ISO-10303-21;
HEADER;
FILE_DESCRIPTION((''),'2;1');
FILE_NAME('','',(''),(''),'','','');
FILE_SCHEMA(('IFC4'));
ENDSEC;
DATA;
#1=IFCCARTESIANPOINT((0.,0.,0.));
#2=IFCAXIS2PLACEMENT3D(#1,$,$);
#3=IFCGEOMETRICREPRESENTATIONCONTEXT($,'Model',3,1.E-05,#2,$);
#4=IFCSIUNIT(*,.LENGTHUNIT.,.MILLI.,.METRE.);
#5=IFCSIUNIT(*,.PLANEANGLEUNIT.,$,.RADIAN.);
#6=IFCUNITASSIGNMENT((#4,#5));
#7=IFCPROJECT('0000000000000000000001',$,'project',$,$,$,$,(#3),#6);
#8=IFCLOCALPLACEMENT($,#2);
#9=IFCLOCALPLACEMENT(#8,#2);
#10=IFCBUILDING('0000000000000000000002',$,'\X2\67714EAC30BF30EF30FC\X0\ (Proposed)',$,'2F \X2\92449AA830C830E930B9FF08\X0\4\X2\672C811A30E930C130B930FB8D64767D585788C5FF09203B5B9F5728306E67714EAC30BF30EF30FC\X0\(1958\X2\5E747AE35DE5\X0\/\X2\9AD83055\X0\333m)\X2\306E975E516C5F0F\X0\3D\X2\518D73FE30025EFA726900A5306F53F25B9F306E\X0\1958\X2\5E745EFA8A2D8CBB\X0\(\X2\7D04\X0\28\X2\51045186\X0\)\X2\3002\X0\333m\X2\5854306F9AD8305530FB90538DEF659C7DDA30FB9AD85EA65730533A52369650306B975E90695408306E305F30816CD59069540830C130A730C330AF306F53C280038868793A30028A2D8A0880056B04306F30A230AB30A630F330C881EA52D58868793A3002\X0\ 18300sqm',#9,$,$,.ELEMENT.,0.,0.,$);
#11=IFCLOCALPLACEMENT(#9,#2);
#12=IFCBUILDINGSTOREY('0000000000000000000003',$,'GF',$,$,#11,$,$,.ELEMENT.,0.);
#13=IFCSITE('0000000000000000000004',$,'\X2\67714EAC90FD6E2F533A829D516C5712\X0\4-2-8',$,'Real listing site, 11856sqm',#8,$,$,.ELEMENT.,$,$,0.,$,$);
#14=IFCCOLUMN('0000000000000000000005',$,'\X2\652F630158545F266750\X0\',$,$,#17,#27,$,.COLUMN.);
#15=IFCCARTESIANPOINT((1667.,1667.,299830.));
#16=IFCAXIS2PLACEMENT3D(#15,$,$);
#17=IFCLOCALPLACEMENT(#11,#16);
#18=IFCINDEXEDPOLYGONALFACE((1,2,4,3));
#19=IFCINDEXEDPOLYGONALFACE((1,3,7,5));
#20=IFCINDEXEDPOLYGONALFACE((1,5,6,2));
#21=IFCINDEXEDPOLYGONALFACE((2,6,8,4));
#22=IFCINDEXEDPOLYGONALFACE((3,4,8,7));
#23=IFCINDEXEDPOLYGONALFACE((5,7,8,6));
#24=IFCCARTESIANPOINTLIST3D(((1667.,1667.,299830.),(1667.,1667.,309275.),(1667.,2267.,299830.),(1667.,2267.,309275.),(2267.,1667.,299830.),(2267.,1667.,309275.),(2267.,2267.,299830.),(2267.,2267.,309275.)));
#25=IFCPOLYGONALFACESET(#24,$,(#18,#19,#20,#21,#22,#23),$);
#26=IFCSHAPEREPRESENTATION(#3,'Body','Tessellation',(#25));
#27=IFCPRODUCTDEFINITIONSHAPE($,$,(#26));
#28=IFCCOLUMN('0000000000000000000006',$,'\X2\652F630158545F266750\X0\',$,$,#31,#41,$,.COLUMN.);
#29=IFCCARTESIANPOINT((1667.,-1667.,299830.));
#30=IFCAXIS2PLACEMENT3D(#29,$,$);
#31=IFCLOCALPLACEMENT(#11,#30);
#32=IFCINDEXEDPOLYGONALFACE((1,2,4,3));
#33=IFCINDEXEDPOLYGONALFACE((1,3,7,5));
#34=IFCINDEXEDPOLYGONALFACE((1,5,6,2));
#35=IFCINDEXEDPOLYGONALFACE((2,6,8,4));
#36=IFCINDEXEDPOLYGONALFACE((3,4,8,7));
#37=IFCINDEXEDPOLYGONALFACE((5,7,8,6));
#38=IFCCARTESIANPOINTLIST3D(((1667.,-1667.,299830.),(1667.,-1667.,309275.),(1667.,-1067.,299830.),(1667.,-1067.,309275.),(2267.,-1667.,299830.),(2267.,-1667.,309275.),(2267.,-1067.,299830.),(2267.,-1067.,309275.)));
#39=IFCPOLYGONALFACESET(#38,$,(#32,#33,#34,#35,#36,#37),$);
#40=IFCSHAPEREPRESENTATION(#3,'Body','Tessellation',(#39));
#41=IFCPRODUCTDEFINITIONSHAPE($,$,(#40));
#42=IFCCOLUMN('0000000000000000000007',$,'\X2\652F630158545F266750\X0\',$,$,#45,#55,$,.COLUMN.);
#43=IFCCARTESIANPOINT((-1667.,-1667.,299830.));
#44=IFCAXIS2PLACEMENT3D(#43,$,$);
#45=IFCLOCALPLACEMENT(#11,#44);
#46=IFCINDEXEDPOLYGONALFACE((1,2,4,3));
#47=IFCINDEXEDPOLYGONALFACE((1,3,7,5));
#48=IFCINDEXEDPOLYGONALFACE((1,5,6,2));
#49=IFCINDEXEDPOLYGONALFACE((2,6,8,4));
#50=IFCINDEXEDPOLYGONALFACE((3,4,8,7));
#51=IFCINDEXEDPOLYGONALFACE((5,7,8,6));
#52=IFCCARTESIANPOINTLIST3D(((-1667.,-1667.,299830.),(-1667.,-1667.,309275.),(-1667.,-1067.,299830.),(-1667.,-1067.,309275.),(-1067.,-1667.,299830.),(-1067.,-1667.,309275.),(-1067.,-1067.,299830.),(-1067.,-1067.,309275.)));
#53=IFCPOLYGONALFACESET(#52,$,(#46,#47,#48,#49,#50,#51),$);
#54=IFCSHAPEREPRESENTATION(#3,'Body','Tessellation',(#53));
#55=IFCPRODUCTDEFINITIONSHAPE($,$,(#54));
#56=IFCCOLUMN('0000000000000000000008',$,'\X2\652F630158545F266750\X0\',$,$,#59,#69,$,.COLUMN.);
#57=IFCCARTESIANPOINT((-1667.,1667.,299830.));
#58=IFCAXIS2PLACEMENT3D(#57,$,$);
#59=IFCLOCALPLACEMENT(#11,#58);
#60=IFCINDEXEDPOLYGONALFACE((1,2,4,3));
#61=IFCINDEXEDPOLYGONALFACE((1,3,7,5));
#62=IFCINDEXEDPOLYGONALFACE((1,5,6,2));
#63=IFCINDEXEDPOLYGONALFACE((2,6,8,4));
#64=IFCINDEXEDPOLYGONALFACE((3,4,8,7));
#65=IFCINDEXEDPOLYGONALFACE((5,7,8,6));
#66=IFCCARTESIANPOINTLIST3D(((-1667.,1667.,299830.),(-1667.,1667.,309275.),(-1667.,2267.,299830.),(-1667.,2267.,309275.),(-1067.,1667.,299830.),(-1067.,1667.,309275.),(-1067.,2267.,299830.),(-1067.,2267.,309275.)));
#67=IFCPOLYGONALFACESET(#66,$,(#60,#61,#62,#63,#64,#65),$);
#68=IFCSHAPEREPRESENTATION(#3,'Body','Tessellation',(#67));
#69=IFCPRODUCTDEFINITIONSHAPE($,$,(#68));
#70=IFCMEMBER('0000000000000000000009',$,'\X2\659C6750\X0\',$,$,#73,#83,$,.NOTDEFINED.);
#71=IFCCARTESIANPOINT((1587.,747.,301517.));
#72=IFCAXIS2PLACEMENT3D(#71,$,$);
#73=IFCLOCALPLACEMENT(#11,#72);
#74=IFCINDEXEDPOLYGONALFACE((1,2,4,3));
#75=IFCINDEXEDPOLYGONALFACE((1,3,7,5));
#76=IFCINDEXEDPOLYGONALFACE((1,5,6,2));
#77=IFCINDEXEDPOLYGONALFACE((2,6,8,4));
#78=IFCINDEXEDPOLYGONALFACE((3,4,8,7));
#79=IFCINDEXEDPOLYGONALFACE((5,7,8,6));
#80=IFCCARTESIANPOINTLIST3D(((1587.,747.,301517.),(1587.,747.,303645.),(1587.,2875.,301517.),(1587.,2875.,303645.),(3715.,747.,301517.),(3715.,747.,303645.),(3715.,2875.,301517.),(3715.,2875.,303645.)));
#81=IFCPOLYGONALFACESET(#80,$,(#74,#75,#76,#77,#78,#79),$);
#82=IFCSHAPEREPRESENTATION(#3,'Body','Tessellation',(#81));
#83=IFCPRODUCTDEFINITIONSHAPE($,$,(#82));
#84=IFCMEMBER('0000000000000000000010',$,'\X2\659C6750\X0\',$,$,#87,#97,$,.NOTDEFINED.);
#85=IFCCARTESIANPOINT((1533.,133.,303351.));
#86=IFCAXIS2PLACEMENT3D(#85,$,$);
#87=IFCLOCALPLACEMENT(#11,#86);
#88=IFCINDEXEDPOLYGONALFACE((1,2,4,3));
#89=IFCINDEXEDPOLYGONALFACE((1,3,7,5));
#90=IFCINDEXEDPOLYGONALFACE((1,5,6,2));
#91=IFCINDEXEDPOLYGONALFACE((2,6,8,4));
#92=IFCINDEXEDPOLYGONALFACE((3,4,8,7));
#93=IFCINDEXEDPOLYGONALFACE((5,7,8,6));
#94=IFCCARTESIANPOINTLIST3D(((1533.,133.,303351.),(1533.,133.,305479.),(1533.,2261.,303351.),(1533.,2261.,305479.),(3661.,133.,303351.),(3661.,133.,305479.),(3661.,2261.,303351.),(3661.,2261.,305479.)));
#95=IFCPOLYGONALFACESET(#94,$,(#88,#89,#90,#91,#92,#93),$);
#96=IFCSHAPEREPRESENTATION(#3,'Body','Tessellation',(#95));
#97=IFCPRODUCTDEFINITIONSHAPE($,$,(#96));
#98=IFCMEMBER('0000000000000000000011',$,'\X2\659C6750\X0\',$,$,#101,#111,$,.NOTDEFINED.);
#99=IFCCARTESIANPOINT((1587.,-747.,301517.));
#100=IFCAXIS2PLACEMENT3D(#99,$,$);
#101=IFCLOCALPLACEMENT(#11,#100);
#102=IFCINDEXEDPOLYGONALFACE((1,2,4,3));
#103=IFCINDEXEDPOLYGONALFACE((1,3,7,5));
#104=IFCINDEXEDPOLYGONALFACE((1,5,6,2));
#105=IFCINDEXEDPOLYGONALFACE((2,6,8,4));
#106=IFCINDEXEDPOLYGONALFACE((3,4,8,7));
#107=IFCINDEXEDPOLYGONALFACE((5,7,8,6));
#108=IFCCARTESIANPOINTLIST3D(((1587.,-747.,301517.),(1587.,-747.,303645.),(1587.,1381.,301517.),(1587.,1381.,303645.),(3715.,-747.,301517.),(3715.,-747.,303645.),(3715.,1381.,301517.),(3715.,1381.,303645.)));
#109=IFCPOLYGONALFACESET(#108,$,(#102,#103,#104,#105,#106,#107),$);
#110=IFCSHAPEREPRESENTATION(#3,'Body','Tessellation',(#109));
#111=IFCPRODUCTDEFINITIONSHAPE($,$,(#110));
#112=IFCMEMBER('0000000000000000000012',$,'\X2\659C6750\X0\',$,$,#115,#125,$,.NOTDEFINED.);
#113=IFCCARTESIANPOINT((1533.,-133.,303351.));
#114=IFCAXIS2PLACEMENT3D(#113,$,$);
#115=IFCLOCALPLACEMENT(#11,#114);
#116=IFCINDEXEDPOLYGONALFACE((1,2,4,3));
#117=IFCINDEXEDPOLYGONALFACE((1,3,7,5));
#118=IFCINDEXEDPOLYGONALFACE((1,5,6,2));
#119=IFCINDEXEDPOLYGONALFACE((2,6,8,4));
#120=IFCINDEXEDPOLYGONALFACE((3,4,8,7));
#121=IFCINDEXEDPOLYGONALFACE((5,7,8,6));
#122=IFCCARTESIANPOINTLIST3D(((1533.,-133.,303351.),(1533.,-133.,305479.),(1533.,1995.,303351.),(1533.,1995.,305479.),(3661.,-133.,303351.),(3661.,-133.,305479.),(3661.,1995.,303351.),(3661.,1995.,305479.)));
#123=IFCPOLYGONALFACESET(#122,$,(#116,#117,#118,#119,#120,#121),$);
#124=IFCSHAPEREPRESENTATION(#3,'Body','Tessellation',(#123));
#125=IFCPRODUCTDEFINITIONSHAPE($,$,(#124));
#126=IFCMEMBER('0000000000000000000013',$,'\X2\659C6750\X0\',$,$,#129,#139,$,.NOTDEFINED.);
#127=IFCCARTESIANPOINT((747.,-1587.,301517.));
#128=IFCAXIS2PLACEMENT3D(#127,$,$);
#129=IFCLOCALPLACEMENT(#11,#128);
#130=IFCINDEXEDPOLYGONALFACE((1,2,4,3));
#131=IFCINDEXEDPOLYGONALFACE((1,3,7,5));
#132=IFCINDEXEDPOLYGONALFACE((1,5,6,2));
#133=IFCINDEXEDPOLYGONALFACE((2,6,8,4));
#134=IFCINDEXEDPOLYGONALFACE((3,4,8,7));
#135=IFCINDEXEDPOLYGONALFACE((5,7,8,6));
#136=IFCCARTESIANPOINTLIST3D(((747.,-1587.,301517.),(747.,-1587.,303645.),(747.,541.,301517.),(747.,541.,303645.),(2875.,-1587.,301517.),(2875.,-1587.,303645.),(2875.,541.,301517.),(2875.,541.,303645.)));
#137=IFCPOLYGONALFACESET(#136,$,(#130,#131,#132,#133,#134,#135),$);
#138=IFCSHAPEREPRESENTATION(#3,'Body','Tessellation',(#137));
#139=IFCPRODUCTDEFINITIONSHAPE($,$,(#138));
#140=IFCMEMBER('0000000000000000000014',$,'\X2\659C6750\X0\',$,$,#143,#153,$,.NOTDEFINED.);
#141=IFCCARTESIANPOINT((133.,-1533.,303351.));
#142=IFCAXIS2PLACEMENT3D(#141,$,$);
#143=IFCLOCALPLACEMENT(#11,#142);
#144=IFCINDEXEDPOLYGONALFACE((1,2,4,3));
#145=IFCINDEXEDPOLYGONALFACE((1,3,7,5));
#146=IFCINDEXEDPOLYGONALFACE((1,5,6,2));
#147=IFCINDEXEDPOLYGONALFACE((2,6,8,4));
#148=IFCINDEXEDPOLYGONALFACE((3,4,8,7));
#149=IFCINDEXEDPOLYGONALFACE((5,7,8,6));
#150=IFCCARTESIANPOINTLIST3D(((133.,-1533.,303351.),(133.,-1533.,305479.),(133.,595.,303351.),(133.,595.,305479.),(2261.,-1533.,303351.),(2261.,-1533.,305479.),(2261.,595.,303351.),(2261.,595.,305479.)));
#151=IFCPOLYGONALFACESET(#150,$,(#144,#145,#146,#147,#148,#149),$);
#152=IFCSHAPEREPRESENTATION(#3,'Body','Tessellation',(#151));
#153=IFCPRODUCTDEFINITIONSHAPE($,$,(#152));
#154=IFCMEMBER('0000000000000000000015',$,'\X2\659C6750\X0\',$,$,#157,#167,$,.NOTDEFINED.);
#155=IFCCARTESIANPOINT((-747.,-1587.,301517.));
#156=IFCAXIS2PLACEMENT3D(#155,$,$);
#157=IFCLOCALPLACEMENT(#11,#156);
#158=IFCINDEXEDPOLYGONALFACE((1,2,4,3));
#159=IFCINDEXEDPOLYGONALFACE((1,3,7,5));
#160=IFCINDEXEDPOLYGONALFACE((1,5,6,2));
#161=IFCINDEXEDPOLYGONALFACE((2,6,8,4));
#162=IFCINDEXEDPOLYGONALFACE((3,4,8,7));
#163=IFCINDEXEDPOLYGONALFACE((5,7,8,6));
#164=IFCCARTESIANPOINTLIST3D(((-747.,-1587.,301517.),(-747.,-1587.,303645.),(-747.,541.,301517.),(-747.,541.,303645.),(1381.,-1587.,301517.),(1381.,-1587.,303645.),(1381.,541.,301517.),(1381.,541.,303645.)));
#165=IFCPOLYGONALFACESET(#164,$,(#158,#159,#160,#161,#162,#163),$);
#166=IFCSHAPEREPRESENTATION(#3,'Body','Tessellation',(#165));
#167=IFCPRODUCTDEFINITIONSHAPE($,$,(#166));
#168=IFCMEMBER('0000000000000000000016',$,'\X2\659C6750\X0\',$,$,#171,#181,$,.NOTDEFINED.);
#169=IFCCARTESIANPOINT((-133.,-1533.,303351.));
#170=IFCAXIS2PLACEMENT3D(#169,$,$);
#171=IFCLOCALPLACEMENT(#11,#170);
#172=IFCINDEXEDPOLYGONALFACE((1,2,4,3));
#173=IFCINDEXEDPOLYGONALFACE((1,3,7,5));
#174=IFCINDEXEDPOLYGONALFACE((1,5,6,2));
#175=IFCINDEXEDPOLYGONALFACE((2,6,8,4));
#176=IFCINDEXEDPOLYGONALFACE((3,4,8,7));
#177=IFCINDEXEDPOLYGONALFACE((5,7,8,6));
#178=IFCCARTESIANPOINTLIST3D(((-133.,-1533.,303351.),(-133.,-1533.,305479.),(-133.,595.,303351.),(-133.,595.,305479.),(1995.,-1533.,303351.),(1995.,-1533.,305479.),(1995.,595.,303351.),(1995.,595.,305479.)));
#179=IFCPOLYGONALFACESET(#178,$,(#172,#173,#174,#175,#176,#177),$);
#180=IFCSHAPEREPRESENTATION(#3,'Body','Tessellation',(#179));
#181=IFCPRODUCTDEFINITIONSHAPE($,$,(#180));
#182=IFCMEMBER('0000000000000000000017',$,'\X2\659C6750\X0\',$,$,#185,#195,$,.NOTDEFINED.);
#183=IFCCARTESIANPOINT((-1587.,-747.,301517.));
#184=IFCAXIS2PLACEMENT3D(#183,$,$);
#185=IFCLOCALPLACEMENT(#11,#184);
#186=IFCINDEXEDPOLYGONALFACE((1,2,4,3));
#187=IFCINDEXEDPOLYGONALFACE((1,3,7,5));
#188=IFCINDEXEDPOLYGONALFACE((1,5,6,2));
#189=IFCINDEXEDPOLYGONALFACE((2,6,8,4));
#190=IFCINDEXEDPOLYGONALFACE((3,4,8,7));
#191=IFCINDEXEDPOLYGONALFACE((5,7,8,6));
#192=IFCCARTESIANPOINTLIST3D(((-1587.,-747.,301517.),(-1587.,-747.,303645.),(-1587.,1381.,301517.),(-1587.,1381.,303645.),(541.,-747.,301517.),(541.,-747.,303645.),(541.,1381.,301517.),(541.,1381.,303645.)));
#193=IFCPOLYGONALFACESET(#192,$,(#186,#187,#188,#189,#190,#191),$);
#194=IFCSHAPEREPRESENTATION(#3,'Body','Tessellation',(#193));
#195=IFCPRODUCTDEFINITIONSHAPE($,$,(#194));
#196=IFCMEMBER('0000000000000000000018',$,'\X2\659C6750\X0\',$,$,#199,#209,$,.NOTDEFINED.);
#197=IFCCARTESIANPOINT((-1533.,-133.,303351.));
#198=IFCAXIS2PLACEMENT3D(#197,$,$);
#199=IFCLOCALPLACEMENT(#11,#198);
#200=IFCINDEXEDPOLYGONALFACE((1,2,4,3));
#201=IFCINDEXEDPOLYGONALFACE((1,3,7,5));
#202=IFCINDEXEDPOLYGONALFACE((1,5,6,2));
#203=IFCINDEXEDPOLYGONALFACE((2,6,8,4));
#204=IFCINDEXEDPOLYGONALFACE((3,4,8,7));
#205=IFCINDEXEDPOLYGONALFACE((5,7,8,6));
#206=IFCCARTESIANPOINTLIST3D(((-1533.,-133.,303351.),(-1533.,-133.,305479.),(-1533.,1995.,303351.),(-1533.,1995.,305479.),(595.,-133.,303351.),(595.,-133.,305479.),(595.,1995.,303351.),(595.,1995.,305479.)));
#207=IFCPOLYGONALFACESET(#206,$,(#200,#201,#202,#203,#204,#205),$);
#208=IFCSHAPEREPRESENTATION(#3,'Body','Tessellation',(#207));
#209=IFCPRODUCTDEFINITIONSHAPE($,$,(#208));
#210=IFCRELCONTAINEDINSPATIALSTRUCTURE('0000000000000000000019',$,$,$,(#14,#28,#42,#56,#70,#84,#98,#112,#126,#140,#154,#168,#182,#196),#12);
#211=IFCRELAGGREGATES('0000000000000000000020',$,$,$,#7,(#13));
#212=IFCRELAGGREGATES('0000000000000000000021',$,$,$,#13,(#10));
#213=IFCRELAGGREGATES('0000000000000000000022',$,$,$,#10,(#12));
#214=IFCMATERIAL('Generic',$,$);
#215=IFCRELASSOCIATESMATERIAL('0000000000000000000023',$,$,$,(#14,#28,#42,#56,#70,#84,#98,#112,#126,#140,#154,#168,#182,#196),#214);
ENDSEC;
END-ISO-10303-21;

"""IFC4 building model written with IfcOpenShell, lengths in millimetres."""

from ifc_helpers import new_model, si_unit, frame, frame_2d, origin, place, context, project, spatial, rectangle, extrude, material, element, save


model = new_model("IFC4")

# Units and contexts
model_context = context("Model", 3, precision=1e-05, world=origin())
ifc_project = project(units=[si_unit("LENGTHUNIT", "METRE", prefix="MILLI"), si_unit("PLANEANGLEUNIT", "RADIAN")], contexts=[model_context])

# Site, building, storey
site_placement = place(None, origin())
site = spatial("IfcSite", under=ifc_project, at=site_placement, Name="東京都港区芝公園4-2-8", ObjectType="Real listing site, 11856sqm", CompositionType="ELEMENT", RefElevation=0.0)
building_placement = place(site_placement, origin())
building = spatial("IfcBuilding", under=site, at=building_placement, Name="東京タワー (Proposed)", ObjectType="2F 鉄骨トラス（4本脚ラチス・赤白塗装）※実在の東京タワー(1958年竣工/高さ333m)の非公式3D再現。建物¥は史実の1958年建設費(約28億円)。333m塔は高さ・道路斜線・高度地区制限に非適合のため法適合チェックは参考表示。設計者欄はアカウント自動表示。 18300sqm", CompositionType="ELEMENT", ElevationOfRefHeight=0.0, ElevationOfTerrain=0.0)
storey_placement = place(building_placement, origin())
storey = spatial("IfcBuildingStorey", under=building, at=storey_placement, Name="GF", CompositionType="ELEMENT", Elevation=0.0)

# Columns
ifc_material = material(Name="Generic")
column_1_placement = place(storey_placement, frame((1667.0, 1667.0, 299830.0)))
element("IfcColumn", 1, at=column_1_placement, inside=storey, material=ifc_material, Name="支持塔弦材", PredefinedType="COLUMN", context=model_context, shape_type="SweptSolid", body=[
    extrude(rectangle(XDim=600.0, YDim=600.0, at=frame_2d((300.0, 300.0))), frame((1667.0, 1667.0, 299830.0)), (0.0, 0.0, 1.0), 9445.0),
])
column_2_placement = place(storey_placement, frame((1667.0, -1667.0, 299830.0)))
element("IfcColumn", 2, at=column_2_placement, inside=storey, material=ifc_material, Name="支持塔弦材", PredefinedType="COLUMN", context=model_context, shape_type="SweptSolid", body=[
    extrude(rectangle(XDim=600.0, YDim=600.0, at=frame_2d((300.0, 300.0))), frame((1667.0, -1667.0, 299830.0)), (0.0, 0.0, 1.0), 9445.0),
])
column_3_placement = place(storey_placement, frame((-1667.0, -1667.0, 299830.0)))
element("IfcColumn", 3, at=column_3_placement, inside=storey, material=ifc_material, Name="支持塔弦材", PredefinedType="COLUMN", context=model_context, shape_type="SweptSolid", body=[
    extrude(rectangle(XDim=600.0, YDim=600.0, at=frame_2d((300.0, 300.0))), frame((-1667.0, -1667.0, 299830.0)), (0.0, 0.0, 1.0), 9445.0),
])
column_4_placement = place(storey_placement, frame((-1667.0, 1667.0, 299830.0)))
element("IfcColumn", 4, at=column_4_placement, inside=storey, material=ifc_material, Name="支持塔弦材", PredefinedType="COLUMN", context=model_context, shape_type="SweptSolid", body=[
    extrude(rectangle(XDim=600.0, YDim=600.0, at=frame_2d((300.0, 300.0))), frame((-1667.0, 1667.0, 299830.0)), (0.0, 0.0, 1.0), 9445.0),
])

# Members
member_1_placement = place(storey_placement, frame((1587.0, 747.0, 301517.0)))
element("IfcMember", 5, at=member_1_placement, inside=storey, material=ifc_material, Name="斜材", PredefinedType="NOTDEFINED", context=model_context, shape_type="SweptSolid", body=[
    extrude(rectangle(XDim=2128.0, YDim=2128.0, at=frame_2d((1064.0, 1064.0))), frame((1587.0, 747.0, 301517.0)), (0.0, 0.0, 1.0), 2128.0),
])
member_2_placement = place(storey_placement, frame((1533.0, 133.0, 303351.0)))
element("IfcMember", 6, at=member_2_placement, inside=storey, material=ifc_material, Name="斜材", PredefinedType="NOTDEFINED", context=model_context, shape_type="SweptSolid", body=[
    extrude(rectangle(XDim=2128.0, YDim=2128.0, at=frame_2d((1064.0, 1064.0))), frame((1533.0, 133.0, 303351.0)), (0.0, 0.0, 1.0), 2128.0),
])
member_3_placement = place(storey_placement, frame((1587.0, -747.0, 301517.0)))
element("IfcMember", 7, at=member_3_placement, inside=storey, material=ifc_material, Name="斜材", PredefinedType="NOTDEFINED", context=model_context, shape_type="SweptSolid", body=[
    extrude(rectangle(XDim=2128.0, YDim=2128.0, at=frame_2d((1064.0, 1064.0))), frame((1587.0, -747.0, 301517.0)), (0.0, 0.0, 1.0), 2128.0),
])
member_4_placement = place(storey_placement, frame((1533.0, -133.0, 303351.0)))
element("IfcMember", 8, at=member_4_placement, inside=storey, material=ifc_material, Name="斜材", PredefinedType="NOTDEFINED", context=model_context, shape_type="SweptSolid", body=[
    extrude(rectangle(XDim=2128.0, YDim=2128.0, at=frame_2d((1064.0, 1064.0))), frame((1533.0, -133.0, 303351.0)), (0.0, 0.0, 1.0), 2128.0),
])
member_5_placement = place(storey_placement, frame((747.0, -1587.0, 301517.0)))
element("IfcMember", 9, at=member_5_placement, inside=storey, material=ifc_material, Name="斜材", PredefinedType="NOTDEFINED", context=model_context, shape_type="SweptSolid", body=[
    extrude(rectangle(XDim=2128.0, YDim=2128.0, at=frame_2d((1064.0, 1064.0))), frame((747.0, -1587.0, 301517.0)), (0.0, 0.0, 1.0), 2128.0),
])
member_6_placement = place(storey_placement, frame((133.0, -1533.0, 303351.0)))
element("IfcMember", 10, at=member_6_placement, inside=storey, material=ifc_material, Name="斜材", PredefinedType="NOTDEFINED", context=model_context, shape_type="SweptSolid", body=[
    extrude(rectangle(XDim=2128.0, YDim=2128.0, at=frame_2d((1064.0, 1064.0))), frame((133.0, -1533.0, 303351.0)), (0.0, 0.0, 1.0), 2128.0),
])
member_7_placement = place(storey_placement, frame((-747.0, -1587.0, 301517.0)))
element("IfcMember", 11, at=member_7_placement, inside=storey, material=ifc_material, Name="斜材", PredefinedType="NOTDEFINED", context=model_context, shape_type="SweptSolid", body=[
    extrude(rectangle(XDim=2128.0, YDim=2128.0, at=frame_2d((1064.0, 1064.0))), frame((-747.0, -1587.0, 301517.0)), (0.0, 0.0, 1.0), 2128.0),
])
member_8_placement = place(storey_placement, frame((-133.0, -1533.0, 303351.0)))
element("IfcMember", 12, at=member_8_placement, inside=storey, material=ifc_material, Name="斜材", PredefinedType="NOTDEFINED", context=model_context, shape_type="SweptSolid", body=[
    extrude(rectangle(XDim=2128.0, YDim=2128.0, at=frame_2d((1064.0, 1064.0))), frame((-133.0, -1533.0, 303351.0)), (0.0, 0.0, 1.0), 2128.0),
])
member_9_placement = place(storey_placement, frame((-1587.0, -747.0, 301517.0)))
element("IfcMember", 13, at=member_9_placement, inside=storey, material=ifc_material, Name="斜材", PredefinedType="NOTDEFINED", context=model_context, shape_type="SweptSolid", body=[
    extrude(rectangle(XDim=2128.0, YDim=2128.0, at=frame_2d((1064.0, 1064.0))), frame((-1587.0, -747.0, 301517.0)), (0.0, 0.0, 1.0), 2128.0),
])
member_10_placement = place(storey_placement, frame((-1533.0, -133.0, 303351.0)))
element("IfcMember", 14, at=member_10_placement, inside=storey, material=ifc_material, Name="斜材", PredefinedType="NOTDEFINED", context=model_context, shape_type="SweptSolid", body=[
    extrude(rectangle(XDim=2128.0, YDim=2128.0, at=frame_2d((1064.0, 1064.0))), frame((-1533.0, -133.0, 303351.0)), (0.0, 0.0, 1.0), 2128.0),
])

save(model, "model.ifc")
